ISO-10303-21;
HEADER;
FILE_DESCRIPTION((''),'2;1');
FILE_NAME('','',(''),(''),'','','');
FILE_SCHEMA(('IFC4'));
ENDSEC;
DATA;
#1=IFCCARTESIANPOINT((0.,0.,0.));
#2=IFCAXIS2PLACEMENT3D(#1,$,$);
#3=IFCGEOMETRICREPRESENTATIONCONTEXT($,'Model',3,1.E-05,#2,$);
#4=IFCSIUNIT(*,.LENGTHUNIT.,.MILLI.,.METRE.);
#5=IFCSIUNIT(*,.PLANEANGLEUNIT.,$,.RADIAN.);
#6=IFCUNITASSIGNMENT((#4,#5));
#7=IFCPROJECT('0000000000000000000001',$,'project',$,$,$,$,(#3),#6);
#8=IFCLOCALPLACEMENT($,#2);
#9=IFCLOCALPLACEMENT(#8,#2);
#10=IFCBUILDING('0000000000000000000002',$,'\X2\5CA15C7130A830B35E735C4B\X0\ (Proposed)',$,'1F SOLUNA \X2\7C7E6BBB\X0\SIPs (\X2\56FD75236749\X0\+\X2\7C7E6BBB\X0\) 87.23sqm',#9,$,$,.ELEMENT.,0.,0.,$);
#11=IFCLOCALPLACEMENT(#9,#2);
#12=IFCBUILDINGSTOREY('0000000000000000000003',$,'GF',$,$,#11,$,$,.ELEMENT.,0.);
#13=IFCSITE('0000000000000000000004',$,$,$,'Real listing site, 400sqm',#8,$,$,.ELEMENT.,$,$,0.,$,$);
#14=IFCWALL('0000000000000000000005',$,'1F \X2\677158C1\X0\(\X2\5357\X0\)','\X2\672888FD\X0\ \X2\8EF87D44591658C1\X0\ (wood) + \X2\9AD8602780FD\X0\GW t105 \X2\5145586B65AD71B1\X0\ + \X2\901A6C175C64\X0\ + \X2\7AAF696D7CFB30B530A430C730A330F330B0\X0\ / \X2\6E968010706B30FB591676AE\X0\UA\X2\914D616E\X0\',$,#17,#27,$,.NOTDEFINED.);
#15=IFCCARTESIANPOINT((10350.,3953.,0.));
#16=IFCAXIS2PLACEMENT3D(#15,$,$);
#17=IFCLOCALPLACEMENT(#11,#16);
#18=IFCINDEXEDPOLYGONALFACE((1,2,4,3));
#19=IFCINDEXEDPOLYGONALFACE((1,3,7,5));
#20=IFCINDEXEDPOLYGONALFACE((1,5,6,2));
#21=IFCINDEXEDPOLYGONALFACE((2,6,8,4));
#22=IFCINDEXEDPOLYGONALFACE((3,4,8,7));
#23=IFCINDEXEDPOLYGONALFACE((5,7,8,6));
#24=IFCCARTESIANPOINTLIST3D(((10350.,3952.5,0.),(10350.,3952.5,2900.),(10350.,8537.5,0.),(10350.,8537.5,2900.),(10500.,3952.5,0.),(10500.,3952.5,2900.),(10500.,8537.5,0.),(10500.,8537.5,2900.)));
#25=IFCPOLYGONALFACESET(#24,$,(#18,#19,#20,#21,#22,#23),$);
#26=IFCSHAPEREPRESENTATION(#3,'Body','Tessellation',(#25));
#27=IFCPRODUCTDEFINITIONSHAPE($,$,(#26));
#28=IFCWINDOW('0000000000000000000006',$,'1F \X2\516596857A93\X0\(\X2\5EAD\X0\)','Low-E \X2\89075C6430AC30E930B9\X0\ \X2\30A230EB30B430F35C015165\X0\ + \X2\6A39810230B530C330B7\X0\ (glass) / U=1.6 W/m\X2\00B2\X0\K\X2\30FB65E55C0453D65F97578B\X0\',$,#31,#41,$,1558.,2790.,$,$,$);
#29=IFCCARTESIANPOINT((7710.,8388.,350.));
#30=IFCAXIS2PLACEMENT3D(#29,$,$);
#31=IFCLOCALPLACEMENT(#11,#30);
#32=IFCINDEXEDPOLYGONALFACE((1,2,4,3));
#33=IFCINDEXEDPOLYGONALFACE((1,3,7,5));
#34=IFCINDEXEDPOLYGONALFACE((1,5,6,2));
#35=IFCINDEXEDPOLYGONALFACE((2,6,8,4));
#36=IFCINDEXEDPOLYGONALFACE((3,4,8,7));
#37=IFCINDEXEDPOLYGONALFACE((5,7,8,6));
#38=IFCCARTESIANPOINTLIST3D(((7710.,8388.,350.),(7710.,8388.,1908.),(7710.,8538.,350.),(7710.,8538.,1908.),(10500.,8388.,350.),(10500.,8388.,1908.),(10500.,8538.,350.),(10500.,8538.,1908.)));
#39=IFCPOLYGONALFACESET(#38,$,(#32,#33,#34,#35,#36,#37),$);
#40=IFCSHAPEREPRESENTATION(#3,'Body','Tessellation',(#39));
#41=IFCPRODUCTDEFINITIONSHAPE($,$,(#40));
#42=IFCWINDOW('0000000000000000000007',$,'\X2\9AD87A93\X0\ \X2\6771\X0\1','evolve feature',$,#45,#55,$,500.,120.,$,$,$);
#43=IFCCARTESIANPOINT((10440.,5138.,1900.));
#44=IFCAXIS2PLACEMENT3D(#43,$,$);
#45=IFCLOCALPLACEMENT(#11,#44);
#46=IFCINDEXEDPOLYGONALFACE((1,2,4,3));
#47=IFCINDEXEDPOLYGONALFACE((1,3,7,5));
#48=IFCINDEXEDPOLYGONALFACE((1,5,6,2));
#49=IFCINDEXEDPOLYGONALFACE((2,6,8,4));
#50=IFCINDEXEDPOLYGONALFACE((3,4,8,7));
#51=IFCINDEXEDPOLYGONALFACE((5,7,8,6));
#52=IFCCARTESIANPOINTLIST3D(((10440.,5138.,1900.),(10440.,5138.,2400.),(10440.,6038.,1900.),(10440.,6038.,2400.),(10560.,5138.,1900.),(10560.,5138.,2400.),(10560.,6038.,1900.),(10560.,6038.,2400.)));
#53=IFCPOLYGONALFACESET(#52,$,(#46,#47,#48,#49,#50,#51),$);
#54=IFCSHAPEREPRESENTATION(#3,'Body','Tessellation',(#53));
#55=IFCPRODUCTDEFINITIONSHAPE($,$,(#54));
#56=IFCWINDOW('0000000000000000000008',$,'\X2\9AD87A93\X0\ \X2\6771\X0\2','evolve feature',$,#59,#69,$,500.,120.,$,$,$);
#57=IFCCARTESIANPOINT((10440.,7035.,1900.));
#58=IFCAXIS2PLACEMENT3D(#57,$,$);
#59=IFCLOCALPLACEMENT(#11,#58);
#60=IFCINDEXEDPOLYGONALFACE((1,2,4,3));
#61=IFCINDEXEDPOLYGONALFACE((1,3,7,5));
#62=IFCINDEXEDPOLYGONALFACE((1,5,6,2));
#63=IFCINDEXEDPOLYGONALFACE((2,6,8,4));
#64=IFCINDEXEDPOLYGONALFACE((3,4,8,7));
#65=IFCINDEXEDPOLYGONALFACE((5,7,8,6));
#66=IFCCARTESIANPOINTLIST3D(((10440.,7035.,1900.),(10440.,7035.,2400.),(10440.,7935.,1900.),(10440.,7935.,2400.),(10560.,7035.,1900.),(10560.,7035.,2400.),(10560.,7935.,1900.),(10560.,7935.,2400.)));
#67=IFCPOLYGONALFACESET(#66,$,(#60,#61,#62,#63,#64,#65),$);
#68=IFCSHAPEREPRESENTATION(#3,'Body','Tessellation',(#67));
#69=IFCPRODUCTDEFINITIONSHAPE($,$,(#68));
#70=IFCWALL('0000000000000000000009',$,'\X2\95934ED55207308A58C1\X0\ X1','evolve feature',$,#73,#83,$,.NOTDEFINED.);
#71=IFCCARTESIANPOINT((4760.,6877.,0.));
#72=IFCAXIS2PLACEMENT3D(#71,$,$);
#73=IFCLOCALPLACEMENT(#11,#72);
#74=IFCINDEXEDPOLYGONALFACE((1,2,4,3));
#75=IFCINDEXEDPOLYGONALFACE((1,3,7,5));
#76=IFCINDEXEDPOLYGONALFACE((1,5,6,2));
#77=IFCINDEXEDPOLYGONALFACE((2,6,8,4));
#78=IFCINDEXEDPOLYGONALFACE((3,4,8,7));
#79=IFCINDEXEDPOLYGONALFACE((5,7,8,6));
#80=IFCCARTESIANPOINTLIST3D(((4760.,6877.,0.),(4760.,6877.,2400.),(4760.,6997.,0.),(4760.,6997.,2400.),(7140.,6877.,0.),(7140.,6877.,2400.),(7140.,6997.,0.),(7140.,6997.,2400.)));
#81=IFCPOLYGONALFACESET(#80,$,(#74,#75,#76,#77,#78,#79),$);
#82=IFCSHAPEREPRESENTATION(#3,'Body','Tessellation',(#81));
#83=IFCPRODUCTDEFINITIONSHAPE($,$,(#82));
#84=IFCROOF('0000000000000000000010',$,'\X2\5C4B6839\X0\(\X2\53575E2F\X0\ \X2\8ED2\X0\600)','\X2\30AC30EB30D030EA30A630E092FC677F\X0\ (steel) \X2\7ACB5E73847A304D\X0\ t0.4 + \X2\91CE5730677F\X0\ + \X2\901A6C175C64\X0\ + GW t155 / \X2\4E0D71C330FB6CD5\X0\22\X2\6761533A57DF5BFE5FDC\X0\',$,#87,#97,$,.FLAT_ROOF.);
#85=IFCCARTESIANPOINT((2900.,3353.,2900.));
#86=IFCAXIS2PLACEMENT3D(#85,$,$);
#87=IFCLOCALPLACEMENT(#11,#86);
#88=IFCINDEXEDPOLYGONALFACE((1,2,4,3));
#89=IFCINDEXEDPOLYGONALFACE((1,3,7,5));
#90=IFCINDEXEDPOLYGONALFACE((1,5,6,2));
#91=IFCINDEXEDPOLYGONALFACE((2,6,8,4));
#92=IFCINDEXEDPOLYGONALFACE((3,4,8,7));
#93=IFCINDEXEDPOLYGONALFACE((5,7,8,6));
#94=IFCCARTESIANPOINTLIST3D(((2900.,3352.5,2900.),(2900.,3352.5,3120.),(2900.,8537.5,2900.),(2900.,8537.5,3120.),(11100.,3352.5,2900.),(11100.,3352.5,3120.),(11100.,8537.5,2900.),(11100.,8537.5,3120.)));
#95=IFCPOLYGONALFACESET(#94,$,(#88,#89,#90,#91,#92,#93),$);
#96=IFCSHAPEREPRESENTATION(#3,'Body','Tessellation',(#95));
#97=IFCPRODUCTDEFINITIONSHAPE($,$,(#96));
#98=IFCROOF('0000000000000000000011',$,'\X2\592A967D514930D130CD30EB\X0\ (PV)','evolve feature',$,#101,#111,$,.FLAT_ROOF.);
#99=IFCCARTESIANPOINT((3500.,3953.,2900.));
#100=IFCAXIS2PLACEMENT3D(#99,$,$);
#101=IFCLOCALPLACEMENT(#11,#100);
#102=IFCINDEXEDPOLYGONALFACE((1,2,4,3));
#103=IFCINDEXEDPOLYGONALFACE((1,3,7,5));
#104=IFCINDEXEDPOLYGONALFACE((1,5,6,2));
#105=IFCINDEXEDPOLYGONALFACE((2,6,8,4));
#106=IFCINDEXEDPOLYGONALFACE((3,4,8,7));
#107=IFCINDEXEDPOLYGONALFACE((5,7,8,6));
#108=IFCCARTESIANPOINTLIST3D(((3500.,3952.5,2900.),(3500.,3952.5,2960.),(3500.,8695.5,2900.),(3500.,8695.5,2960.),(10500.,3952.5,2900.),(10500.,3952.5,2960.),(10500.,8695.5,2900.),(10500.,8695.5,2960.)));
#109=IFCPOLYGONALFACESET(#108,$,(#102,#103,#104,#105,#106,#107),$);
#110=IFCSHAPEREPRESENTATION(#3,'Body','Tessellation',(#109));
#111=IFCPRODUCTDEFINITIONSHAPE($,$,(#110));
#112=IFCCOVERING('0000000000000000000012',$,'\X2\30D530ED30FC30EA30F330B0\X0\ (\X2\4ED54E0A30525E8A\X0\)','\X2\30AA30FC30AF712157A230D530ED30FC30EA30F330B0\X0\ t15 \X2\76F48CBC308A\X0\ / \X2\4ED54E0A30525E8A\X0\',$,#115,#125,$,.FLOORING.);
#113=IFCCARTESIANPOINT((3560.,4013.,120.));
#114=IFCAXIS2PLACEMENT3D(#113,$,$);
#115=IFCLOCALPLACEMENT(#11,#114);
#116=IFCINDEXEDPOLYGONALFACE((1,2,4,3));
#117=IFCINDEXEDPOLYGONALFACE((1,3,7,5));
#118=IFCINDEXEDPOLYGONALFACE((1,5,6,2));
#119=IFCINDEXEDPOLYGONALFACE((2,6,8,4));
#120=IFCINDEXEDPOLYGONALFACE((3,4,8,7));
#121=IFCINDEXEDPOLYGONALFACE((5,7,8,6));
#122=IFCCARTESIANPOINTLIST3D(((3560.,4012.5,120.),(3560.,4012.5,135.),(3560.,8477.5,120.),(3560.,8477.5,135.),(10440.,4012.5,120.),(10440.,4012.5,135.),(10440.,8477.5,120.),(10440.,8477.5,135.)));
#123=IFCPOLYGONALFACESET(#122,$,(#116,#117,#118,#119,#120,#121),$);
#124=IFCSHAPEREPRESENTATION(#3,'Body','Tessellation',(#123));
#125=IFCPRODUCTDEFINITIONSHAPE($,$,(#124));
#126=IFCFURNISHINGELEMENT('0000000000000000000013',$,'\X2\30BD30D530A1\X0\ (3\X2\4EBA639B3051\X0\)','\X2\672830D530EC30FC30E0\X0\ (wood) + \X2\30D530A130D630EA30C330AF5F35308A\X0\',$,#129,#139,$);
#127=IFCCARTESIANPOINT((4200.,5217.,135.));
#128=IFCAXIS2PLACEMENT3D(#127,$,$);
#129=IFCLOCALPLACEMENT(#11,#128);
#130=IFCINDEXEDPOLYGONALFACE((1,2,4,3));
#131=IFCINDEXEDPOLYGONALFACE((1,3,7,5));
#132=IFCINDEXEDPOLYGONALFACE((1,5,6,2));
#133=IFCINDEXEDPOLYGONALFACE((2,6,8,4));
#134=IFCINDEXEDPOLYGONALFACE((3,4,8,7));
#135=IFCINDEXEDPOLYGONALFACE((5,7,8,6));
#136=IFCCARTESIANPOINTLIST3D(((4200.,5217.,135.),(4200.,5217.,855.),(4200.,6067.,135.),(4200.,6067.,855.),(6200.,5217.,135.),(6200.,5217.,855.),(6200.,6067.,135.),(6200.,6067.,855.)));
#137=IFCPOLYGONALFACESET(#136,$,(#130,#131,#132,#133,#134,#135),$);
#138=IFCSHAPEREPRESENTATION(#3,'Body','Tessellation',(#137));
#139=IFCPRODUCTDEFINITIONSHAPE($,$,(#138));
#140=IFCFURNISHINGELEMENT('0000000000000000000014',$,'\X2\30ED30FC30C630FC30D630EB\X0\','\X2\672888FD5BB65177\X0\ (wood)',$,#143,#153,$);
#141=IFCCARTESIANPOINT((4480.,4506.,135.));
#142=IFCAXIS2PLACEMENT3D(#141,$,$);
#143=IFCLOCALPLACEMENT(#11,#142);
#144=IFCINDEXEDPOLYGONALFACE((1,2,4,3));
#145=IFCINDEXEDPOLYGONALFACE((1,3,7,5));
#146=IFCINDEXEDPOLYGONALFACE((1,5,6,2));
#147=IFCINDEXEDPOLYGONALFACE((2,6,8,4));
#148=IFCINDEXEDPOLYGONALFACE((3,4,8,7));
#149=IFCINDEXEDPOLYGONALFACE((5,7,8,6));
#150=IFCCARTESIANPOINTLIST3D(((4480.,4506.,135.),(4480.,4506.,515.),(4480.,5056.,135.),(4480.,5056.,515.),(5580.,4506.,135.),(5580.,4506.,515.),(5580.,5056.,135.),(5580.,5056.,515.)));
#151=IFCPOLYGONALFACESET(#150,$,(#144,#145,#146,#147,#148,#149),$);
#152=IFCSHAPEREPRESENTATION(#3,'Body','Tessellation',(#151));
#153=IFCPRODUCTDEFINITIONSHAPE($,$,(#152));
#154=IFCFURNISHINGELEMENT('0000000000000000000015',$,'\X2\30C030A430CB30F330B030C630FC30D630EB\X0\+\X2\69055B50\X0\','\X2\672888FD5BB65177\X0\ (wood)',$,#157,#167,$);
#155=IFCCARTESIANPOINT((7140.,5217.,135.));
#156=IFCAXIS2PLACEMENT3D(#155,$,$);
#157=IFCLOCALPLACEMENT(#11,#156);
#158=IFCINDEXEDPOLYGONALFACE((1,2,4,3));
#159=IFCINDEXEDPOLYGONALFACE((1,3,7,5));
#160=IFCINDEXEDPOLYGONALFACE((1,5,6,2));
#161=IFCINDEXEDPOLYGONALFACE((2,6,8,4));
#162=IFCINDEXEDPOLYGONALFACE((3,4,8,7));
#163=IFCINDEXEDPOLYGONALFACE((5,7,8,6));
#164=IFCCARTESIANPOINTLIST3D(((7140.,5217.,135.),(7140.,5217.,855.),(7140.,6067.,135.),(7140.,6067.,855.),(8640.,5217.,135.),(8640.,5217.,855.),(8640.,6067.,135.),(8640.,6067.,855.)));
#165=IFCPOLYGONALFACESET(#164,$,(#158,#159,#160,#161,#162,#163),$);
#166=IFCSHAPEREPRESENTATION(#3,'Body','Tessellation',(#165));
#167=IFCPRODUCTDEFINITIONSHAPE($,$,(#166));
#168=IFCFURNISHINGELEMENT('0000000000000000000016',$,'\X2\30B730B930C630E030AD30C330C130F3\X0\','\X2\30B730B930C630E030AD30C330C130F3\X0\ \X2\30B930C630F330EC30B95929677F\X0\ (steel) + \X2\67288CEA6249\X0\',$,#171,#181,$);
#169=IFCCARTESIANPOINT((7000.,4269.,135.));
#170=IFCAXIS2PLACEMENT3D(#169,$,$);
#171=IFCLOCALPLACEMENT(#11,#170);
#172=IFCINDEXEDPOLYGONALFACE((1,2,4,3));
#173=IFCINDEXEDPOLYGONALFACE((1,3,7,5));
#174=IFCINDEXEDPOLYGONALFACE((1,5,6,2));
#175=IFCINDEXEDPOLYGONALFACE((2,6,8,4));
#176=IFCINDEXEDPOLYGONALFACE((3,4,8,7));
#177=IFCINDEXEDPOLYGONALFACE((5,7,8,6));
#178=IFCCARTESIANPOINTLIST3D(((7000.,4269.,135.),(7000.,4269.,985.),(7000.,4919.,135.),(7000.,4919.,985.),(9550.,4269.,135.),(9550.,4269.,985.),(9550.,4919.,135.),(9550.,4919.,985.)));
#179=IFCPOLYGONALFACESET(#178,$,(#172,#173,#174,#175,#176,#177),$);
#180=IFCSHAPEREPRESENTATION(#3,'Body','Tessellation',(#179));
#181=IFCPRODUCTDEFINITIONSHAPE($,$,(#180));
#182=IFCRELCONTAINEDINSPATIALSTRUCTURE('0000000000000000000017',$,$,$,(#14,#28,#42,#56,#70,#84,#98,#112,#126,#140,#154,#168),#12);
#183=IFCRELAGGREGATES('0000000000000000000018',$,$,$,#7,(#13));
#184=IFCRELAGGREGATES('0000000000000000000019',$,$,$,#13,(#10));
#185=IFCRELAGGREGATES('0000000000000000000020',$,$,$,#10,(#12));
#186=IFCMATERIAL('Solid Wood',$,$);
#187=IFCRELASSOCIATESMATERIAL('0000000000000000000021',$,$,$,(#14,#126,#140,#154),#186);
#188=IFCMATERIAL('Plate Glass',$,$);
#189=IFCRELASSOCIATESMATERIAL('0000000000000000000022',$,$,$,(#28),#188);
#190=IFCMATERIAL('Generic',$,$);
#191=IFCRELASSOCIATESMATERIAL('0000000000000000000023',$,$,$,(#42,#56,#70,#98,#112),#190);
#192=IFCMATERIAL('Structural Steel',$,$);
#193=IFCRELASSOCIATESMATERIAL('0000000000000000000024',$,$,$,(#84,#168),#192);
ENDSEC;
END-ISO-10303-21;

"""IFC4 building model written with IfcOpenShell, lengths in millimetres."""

from ifc_helpers import new_model, si_unit, frame, frame_2d, origin, place, context, project, spatial, rectangle, extrude, material, element, fill, save


model = new_model("IFC4")

# Units and contexts
model_context = context("Model", 3, precision=1e-05, world=origin())
ifc_project = project(units=[si_unit("LENGTHUNIT", "METRE", prefix="MILLI"), si_unit("PLANEANGLEUNIT", "RADIAN")], contexts=[model_context])

# Site, building, storey
site_placement = place(None, origin())
site = spatial("IfcSite", under=ifc_project, at=site_placement, ObjectType="Real listing site, 400sqm", CompositionType="ELEMENT", RefElevation=0.0)
building_placement = place(site_placement, origin())
building = spatial("IfcBuilding", under=site, at=building_placement, Name="岡山エコ平屋 (Proposed)", ObjectType="1F SOLUNA 籾殻SIPs (国産杉+籾殻) 87.23sqm", CompositionType="ELEMENT", ElevationOfRefHeight=0.0, ElevationOfTerrain=0.0)
storey_placement = place(building_placement, origin())
storey = spatial("IfcBuildingStorey", under=building, at=storey_placement, Name="GF", CompositionType="ELEMENT", Elevation=0.0)

# Shared definitions
ifc_material_1 = material(Name="Solid Wood")
ifc_material_2 = material(Name="Generic")

# Shared definitions
ifc_material_3 = material(Name="Plate Glass")

# Wall, openings, windows
wall_1_placement = place(storey_placement, frame((10350.0, 3953.0, 0.0)))
wall_1 = element("IfcWall", 1, at=wall_1_placement, inside=storey, material=ifc_material_1, Name="1F 東壁(南)", Description="木製 軸組外壁 (wood) + 高性能GW t105 充填断熱 + 通気層 + 窯業系サイディング / 準耐火・外皮UA配慮", PredefinedType="NOTDEFINED", context=model_context, shape_type="SweptSolid", body=[
    extrude(rectangle(XDim=150.0, YDim=4585.0, at=frame_2d((75.0, 2292.0))), frame((10350.0, 3953.0, 0.0)), (0.0, 0.0, 1.0), 2900.0),
])
opening_1_placement = place(storey_placement, frame((7710.0, 8388.0, 350.0)))
opening_1 = element("IfcOpeningElement", 2, at=opening_1_placement, cuts=wall_1, PredefinedType="NOTDEFINED", context=model_context, shape_type="SweptSolid", body=[
    extrude(rectangle(XDim=2790.0, YDim=150.0, at=frame_2d((1395.0, 75.0))), frame((7710.0, 8388.0, 350.0)), (0.0, 0.0, 1.0), 1558.0),
])
opening_2_placement = place(storey_placement, frame((10440.0, 5138.0, 1900.0)))
opening_2 = element("IfcOpeningElement", 3, at=opening_2_placement, cuts=wall_1, PredefinedType="NOTDEFINED", context=model_context, shape_type="SweptSolid", body=[
    extrude(rectangle(XDim=120.0, YDim=900.0, at=frame_2d((60.0, 450.0))), frame((10440.0, 5138.0, 1900.0)), (0.0, 0.0, 1.0), 500.0),
])
opening_3_placement = place(storey_placement, frame((10440.0, 7035.0, 1900.0)))
opening_3 = element("IfcOpeningElement", 4, at=opening_3_placement, cuts=wall_1, PredefinedType="NOTDEFINED", context=model_context, shape_type="SweptSolid", body=[
    extrude(rectangle(XDim=120.0, YDim=900.0, at=frame_2d((60.0, 450.0))), frame((10440.0, 7035.0, 1900.0)), (0.0, 0.0, 1.0), 500.0),
])
window_1_placement = place(storey_placement, frame((7710.0, 8388.0, 350.0)))
window_1 = element("IfcWindow", 5, at=window_1_placement, inside=storey, material=ifc_material_3, Name="1F 入隅窓(庭)", Description="Low-E 複層ガラス アルゴン封入 + 樹脂サッシ (glass) / U=1.6 W/m²K・日射取得型", OverallHeight=1558.0, OverallWidth=2790.0, context=model_context, shape_type="SweptSolid", body=[
    extrude(rectangle(XDim=2790.0, YDim=150.0, at=frame_2d((1395.0, 75.0))), frame((7710.0, 8388.0, 350.0)), (0.0, 0.0, 1.0), 1558.0),
])
fill(opening_1, window_1)
window_2_placement = place(storey_placement, frame((10440.0, 5138.0, 1900.0)))
window_2 = element("IfcWindow", 6, at=window_2_placement, inside=storey, material=ifc_material_2, Name="高窓 東1", Description="evolve feature", OverallHeight=500.0, OverallWidth=120.0, context=model_context, shape_type="SweptSolid", body=[
    extrude(rectangle(XDim=120.0, YDim=900.0, at=frame_2d((60.0, 450.0))), frame((10440.0, 5138.0, 1900.0)), (0.0, 0.0, 1.0), 500.0),
])
fill(opening_2, window_2)
window_3_placement = place(storey_placement, frame((10440.0, 7035.0, 1900.0)))
window_3 = element("IfcWindow", 7, at=window_3_placement, inside=storey, material=ifc_material_2, Name="高窓 東2", Description="evolve feature", OverallHeight=500.0, OverallWidth=120.0, context=model_context, shape_type="SweptSolid", body=[
    extrude(rectangle(XDim=120.0, YDim=900.0, at=frame_2d((60.0, 450.0))), frame((10440.0, 7035.0, 1900.0)), (0.0, 0.0, 1.0), 500.0),
])
fill(opening_3, window_3)

# Wall
wall_2_placement = place(storey_placement, frame((4760.0, 6877.0, 0.0)))
element("IfcWall", 8, at=wall_2_placement, inside=storey, material=ifc_material_2, Name="間仕切り壁 X1", Description="evolve feature", PredefinedType="NOTDEFINED", context=model_context, shape_type="SweptSolid", body=[
    extrude(rectangle(XDim=2380.0, YDim=120.0, at=frame_2d((1190.0, 60.0))), frame((4760.0, 6877.0, 0.0)), (0.0, 0.0, 1.0), 2400.0),
])

# Roofs
ifc_material_4 = material(Name="Structural Steel")
roof_1_placement = place(storey_placement, frame((2900.0, 3353.0, 2900.0)))
element("IfcRoof", 9, at=roof_1_placement, inside=storey, material=ifc_material_4, Name="屋根(南帯 軒600)", Description="ガルバリウム鋼板 (steel) 立平葺き t0.4 + 野地板 + 通気層 + GW t155 / 不燃・法22条区域対応", PredefinedType="FLAT_ROOF", context=model_context, shape_type="SweptSolid", body=[
    extrude(rectangle(XDim=8200.0, YDim=5185.0, at=frame_2d((4100.0, 2592.0))), frame((2900.0, 3353.0, 2900.0)), (0.0, 0.0, 1.0), 220.0),
])
roof_2_placement = place(storey_placement, frame((3500.0, 3953.0, 2900.0)))
element("IfcRoof", 10, at=roof_2_placement, inside=storey, material=ifc_material_2, Name="太陽光パネル (PV)", Description="evolve feature", PredefinedType="FLAT_ROOF", context=model_context, shape_type="SweptSolid", body=[
    extrude(rectangle(XDim=7000.0, YDim=4743.0, at=frame_2d((3500.0, 2371.0))), frame((3500.0, 3953.0, 2900.0)), (0.0, 0.0, 1.0), 60.0),
])

# Covering
covering_placement = place(storey_placement, frame((3560.0, 4013.0, 120.0)))
element("IfcCovering", 11, at=covering_placement, inside=storey, material=ifc_material_2, Name="フローリング (仕上げ床)", Description="オーク無垢フローリング t15 直貼り / 仕上げ床", PredefinedType="FLOORING", context=model_context, shape_type="SweptSolid", body=[
    extrude(rectangle(XDim=6880.0, YDim=4465.0, at=frame_2d((3440.0, 2232.0))), frame((3560.0, 4013.0, 120.0)), (0.0, 0.0, 1.0), 15.0),
])

# Furnishing elements
furnishing_1_placement = place(storey_placement, frame((4200.0, 5217.0, 135.0)))
element("IfcFurnishingElement", 12, at=furnishing_1_placement, inside=storey, material=ifc_material_1, Name="ソファ (3人掛け)", Description="木フレーム (wood) + ファブリック張り", context=model_context, shape_type="SweptSolid", body=[
    extrude(rectangle(XDim=2000.0, YDim=850.0, at=frame_2d((1000.0, 425.0))), frame((4200.0, 5217.0, 135.0)), (0.0, 0.0, 1.0), 720.0),
])
furnishing_2_placement = place(storey_placement, frame((4480.0, 4506.0, 135.0)))
element("IfcFurnishingElement", 13, at=furnishing_2_placement, inside=storey, material=ifc_material_1, Name="ローテーブル", Description="木製家具 (wood)", context=model_context, shape_type="SweptSolid", body=[
    extrude(rectangle(XDim=1100.0, YDim=550.0, at=frame_2d((550.0, 275.0))), frame((4480.0, 4506.0, 135.0)), (0.0, 0.0, 1.0), 380.0),
])
furnishing_3_placement = place(storey_placement, frame((7140.0, 5217.0, 135.0)))
element("IfcFurnishingElement", 14, at=furnishing_3_placement, inside=storey, material=ifc_material_1, Name="ダイニングテーブル+椅子", Description="木製家具 (wood)", context=model_context, shape_type="SweptSolid", body=[
    extrude(rectangle(XDim=1500.0, YDim=850.0, at=frame_2d((750.0, 425.0))), frame((7140.0, 5217.0, 135.0)), (0.0, 0.0, 1.0), 720.0),
])
furnishing_4_placement = place(storey_placement, frame((7000.0, 4269.0, 135.0)))
element("IfcFurnishingElement", 15, at=furnishing_4_placement, inside=storey, material=ifc_material_4, Name="システムキッチン", Description="システムキッチン ステンレス天板 (steel) + 木質扉", context=model_context, shape_type="SweptSolid", body=[
    extrude(rectangle(XDim=2550.0, YDim=650.0, at=frame_2d((1275.0, 325.0))), frame((7000.0, 4269.0, 135.0)), (0.0, 0.0, 1.0), 850.0),
])

save(model, "model.ifc")
